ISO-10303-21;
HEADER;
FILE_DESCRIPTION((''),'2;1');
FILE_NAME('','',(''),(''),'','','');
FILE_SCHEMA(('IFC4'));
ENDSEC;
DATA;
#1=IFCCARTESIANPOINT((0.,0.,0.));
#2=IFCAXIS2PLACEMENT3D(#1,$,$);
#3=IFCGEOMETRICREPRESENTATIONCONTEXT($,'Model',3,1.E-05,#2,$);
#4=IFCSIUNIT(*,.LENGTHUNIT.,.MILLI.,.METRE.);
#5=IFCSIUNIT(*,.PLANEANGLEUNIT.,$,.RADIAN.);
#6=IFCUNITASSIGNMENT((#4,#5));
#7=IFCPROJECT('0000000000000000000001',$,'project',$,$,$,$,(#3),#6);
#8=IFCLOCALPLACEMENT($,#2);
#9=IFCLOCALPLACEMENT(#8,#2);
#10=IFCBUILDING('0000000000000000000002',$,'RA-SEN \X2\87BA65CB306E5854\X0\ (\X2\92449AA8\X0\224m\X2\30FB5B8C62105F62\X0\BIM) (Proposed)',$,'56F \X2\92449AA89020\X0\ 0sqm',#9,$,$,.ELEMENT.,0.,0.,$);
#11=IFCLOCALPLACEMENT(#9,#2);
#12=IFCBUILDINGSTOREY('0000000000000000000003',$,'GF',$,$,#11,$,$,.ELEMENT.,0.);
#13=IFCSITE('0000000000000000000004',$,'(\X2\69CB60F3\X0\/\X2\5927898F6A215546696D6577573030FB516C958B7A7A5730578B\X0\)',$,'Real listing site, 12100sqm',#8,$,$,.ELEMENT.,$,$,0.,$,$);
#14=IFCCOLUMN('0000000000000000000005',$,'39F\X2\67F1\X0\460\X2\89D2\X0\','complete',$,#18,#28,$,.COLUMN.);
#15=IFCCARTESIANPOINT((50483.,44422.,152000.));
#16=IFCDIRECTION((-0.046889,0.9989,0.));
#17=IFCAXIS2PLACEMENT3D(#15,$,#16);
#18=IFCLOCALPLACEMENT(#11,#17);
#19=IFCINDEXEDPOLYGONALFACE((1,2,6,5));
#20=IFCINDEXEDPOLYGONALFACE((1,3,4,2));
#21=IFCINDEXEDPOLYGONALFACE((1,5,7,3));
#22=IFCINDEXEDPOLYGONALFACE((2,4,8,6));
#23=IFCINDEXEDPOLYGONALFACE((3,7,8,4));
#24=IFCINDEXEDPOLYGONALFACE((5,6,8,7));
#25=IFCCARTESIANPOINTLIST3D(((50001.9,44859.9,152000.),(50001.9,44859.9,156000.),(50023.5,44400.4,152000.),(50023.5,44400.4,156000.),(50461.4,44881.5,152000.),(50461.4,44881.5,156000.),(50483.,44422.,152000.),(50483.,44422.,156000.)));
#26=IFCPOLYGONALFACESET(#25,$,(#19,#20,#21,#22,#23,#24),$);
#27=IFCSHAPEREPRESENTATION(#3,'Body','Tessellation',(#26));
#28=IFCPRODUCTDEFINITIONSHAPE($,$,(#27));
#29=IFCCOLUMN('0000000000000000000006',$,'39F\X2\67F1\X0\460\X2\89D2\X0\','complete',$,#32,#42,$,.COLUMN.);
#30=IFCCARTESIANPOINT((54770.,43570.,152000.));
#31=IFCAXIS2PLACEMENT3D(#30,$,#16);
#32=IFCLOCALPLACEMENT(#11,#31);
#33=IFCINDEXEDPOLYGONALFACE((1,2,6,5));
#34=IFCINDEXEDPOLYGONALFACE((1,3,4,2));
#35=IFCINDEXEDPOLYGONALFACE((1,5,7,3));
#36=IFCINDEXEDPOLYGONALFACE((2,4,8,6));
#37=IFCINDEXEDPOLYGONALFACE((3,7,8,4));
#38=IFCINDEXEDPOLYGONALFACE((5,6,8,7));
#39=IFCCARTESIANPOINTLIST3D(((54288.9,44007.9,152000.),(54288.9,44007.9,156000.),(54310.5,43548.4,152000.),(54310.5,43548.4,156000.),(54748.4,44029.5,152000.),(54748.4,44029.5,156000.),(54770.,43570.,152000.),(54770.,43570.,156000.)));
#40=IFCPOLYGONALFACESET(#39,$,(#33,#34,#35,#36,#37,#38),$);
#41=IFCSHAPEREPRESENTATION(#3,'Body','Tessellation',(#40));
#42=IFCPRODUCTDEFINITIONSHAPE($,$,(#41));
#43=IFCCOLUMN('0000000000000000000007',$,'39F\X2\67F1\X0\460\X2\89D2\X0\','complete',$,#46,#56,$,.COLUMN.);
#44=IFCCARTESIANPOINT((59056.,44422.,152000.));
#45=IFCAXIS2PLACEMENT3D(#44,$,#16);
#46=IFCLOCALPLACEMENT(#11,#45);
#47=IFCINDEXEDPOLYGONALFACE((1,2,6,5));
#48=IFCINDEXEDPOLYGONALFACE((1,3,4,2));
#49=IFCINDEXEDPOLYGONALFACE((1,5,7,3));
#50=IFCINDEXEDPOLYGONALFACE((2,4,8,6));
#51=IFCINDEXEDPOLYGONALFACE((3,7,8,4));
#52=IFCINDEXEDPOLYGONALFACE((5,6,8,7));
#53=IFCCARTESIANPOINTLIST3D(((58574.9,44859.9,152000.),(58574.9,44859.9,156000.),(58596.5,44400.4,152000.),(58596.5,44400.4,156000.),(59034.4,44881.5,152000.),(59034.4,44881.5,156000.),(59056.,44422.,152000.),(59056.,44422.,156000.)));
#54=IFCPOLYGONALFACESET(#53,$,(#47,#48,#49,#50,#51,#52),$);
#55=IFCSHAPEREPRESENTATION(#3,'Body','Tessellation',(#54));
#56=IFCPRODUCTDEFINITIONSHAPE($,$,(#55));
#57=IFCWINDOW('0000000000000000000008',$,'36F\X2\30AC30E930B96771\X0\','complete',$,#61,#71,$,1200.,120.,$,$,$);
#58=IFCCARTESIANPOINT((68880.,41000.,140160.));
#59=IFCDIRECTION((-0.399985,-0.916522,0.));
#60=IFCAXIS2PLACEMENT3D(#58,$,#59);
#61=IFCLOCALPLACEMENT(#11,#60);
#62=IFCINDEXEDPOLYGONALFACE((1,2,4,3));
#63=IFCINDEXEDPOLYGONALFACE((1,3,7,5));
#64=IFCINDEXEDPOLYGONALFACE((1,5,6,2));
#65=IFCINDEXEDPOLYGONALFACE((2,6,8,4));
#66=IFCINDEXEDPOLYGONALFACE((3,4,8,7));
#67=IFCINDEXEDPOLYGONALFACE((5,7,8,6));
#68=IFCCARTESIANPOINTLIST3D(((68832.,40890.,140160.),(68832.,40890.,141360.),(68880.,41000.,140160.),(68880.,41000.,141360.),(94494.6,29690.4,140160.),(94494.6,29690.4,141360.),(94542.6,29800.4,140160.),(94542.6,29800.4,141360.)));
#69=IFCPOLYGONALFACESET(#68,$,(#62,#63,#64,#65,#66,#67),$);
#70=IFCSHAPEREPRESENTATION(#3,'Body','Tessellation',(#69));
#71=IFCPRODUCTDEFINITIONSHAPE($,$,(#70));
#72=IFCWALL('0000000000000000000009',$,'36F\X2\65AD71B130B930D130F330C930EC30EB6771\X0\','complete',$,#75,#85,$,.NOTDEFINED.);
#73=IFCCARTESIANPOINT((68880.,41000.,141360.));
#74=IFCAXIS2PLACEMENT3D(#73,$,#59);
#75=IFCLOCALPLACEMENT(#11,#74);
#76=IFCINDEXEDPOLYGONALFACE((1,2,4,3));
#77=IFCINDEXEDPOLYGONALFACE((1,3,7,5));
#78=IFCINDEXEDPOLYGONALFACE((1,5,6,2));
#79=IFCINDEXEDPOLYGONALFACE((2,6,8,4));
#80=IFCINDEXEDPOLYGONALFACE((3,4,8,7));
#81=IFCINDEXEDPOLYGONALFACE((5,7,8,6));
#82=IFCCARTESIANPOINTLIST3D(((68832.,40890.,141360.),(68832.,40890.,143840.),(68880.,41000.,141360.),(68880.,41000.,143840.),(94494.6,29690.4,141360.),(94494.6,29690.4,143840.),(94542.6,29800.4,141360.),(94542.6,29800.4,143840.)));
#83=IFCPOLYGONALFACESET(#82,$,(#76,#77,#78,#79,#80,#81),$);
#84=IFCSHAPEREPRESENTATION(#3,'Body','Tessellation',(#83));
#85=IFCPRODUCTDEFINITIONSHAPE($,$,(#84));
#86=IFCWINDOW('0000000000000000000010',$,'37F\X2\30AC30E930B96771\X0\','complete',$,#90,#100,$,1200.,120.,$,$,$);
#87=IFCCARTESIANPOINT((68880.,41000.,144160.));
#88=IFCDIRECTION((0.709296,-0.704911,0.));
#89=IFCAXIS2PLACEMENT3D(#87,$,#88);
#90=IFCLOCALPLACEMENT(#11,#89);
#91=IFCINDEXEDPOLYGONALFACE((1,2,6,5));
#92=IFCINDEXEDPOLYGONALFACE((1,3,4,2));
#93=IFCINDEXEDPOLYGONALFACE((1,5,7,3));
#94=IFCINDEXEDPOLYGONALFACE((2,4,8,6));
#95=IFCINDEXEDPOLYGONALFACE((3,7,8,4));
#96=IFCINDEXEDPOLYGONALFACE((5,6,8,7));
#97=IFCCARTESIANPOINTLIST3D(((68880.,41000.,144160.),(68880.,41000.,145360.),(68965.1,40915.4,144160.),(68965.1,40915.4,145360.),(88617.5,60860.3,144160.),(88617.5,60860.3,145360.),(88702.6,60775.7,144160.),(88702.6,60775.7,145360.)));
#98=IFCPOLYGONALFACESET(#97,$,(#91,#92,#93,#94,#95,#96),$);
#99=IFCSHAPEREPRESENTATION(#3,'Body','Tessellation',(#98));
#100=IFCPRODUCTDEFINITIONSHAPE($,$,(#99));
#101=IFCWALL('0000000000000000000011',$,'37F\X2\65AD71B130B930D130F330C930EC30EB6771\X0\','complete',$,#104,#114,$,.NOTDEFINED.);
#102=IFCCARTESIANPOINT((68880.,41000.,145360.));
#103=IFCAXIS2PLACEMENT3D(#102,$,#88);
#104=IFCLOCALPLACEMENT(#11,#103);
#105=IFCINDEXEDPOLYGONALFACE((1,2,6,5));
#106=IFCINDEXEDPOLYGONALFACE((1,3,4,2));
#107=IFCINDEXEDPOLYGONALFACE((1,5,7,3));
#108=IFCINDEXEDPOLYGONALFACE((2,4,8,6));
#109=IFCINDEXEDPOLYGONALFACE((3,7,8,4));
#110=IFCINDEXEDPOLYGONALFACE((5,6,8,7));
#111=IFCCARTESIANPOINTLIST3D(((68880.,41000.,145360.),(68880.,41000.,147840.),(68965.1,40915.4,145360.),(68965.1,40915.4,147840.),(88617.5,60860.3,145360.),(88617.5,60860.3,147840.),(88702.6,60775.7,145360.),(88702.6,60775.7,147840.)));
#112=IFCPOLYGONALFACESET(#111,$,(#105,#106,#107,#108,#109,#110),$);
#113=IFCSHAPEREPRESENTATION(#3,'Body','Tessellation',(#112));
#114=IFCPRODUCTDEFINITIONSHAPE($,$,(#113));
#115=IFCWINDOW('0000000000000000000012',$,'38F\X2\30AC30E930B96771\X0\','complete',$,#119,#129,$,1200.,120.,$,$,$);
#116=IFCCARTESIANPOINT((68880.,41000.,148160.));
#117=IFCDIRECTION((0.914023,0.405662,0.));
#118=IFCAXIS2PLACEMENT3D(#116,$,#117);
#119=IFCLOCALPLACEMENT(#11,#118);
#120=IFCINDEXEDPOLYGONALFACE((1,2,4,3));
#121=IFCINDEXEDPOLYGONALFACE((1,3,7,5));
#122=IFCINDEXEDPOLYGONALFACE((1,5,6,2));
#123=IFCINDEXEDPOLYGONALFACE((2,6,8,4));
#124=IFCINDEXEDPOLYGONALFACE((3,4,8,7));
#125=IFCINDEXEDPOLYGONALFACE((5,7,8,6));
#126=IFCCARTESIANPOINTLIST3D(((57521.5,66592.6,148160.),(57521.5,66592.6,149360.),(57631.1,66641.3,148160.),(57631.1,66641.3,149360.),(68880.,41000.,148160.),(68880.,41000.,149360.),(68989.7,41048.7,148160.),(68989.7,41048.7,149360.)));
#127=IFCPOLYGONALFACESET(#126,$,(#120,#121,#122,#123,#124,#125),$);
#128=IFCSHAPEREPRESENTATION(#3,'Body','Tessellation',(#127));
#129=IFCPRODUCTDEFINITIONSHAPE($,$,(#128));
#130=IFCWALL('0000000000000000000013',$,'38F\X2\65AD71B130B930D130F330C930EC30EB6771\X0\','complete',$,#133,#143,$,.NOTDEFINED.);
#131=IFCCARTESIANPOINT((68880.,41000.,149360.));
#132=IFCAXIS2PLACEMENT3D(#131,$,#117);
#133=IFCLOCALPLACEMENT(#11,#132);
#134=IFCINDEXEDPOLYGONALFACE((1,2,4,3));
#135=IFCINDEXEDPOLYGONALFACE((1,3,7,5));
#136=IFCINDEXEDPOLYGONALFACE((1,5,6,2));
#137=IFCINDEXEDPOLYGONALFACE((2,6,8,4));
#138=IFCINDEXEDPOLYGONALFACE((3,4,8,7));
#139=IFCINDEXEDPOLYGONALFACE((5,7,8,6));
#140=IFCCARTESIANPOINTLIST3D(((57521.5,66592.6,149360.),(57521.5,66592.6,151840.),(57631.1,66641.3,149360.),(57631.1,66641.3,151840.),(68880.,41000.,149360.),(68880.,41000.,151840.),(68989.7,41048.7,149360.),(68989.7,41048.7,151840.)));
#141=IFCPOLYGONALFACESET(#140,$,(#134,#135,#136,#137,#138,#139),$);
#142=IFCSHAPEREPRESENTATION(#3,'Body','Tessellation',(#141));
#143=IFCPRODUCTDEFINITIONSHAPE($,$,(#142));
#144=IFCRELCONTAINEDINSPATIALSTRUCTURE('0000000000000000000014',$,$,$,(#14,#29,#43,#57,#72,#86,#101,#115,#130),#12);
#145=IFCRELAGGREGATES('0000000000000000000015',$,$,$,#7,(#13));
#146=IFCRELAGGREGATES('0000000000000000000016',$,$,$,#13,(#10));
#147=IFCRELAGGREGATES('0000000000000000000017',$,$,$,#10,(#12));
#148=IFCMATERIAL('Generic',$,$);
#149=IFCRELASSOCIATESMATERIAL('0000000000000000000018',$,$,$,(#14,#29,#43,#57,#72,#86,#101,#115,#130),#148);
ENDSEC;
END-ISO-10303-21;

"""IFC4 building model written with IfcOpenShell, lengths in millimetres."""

from ifc_helpers import new_model, si_unit, frame, frame_2d, origin, place, context, project, spatial, rectangle, extrude, material, element, save


model = new_model("IFC4")

# Units and contexts
model_context = context("Model", 3, precision=1e-05, world=origin())
ifc_project = project(units=[si_unit("LENGTHUNIT", "METRE", prefix="MILLI"), si_unit("PLANEANGLEUNIT", "RADIAN")], contexts=[model_context])

# Site, building, storey
site_placement = place(None, origin())
site = spatial("IfcSite", under=ifc_project, at=site_placement, Name="(構想/大規模商業敷地・公開空地型)", ObjectType="Real listing site, 12100sqm", CompositionType="ELEMENT", RefElevation=0.0)
building_placement = place(site_placement, origin())
building = spatial("IfcBuilding", under=site, at=building_placement, Name="RA-SEN 螺旋の塔 (鉄骨224m・完成形BIM) (Proposed)", ObjectType="56F 鉄骨造 0sqm", CompositionType="ELEMENT", ElevationOfRefHeight=0.0, ElevationOfTerrain=0.0)
storey_placement = place(building_placement, origin())
storey = spatial("IfcBuildingStorey", under=building, at=storey_placement, Name="GF", CompositionType="ELEMENT", Elevation=0.0)

# Columns
ifc_material = material(Name="Generic")
column_1_placement = place(storey_placement, frame((50483.0, 44422.0, 152000.0), x_axis=(-0.046889, 0.9989, 0.0)))
element("IfcColumn", 1, at=column_1_placement, inside=storey, material=ifc_material, Name="39F柱460角", Description="complete", PredefinedType="COLUMN", context=model_context, shape_type="SweptSolid", body=[
    extrude(rectangle(XDim=460.0, YDim=460.0, at=frame_2d((230.0, 230.0))), frame((50483.0, 44422.0, 152000.0), x_axis=(-0.046889, 0.9989, 0.0)), (0.0, 0.0, 1.0), 4000.0),
])
column_2_placement = place(storey_placement, frame((54770.0, 43570.0, 152000.0), x_axis=(-0.046889, 0.9989, 0.0)))
element("IfcColumn", 2, at=column_2_placement, inside=storey, material=ifc_material, Name="39F柱460角", Description="complete", PredefinedType="COLUMN", context=model_context, shape_type="SweptSolid", body=[
    extrude(rectangle(XDim=460.0, YDim=460.0, at=frame_2d((230.0, 230.0))), frame((54770.0, 43570.0, 152000.0), x_axis=(-0.046889, 0.9989, 0.0)), (0.0, 0.0, 1.0), 4000.0),
])
column_3_placement = place(storey_placement, frame((59056.0, 44422.0, 152000.0), x_axis=(-0.046889, 0.9989, 0.0)))
element("IfcColumn", 3, at=column_3_placement, inside=storey, material=ifc_material, Name="39F柱460角", Description="complete", PredefinedType="COLUMN", context=model_context, shape_type="SweptSolid", body=[
    extrude(rectangle(XDim=460.0, YDim=460.0, at=frame_2d((230.0, 230.0))), frame((59056.0, 44422.0, 152000.0), x_axis=(-0.046889, 0.9989, 0.0)), (0.0, 0.0, 1.0), 4000.0),
])

# Window
window_1_placement = place(storey_placement, frame((68880.0, 41000.0, 140160.0), x_axis=(-0.399985, -0.916522, 0.0)))
element("IfcWindow", 4, at=window_1_placement, inside=storey, material=ifc_material, Name="36Fガラス東", Description="complete", OverallHeight=1200.0, OverallWidth=120.0, context=model_context, shape_type="SweptSolid", body=[
    extrude(rectangle(XDim=120.0, YDim=28000.0, at=frame_2d((60.0, 14000.0))), frame((68880.0, 41000.0, 140160.0), x_axis=(-0.399985, -0.916522, 0.0)), (0.0, 0.0, 1.0), 1200.0),
])

# Wall
wall_1_placement = place(storey_placement, frame((68880.0, 41000.0, 141360.0), x_axis=(-0.399985, -0.916522, 0.0)))
element("IfcWall", 5, at=wall_1_placement, inside=storey, material=ifc_material, Name="36F断熱スパンドレル東", Description="complete", PredefinedType="NOTDEFINED", context=model_context, shape_type="SweptSolid", body=[
    extrude(rectangle(XDim=120.0, YDim=28000.0, at=frame_2d((60.0, 14000.0))), frame((68880.0, 41000.0, 141360.0), x_axis=(-0.399985, -0.916522, 0.0)), (0.0, 0.0, 1.0), 2480.0),
])

# Window
window_2_placement = place(storey_placement, frame((68880.0, 41000.0, 144160.0), x_axis=(0.709296, -0.704911, 0.0)))
element("IfcWindow", 6, at=window_2_placement, inside=storey, material=ifc_material, Name="37Fガラス東", Description="complete", OverallHeight=1200.0, OverallWidth=120.0, context=model_context, shape_type="SweptSolid", body=[
    extrude(rectangle(XDim=120.0, YDim=28000.0, at=frame_2d((60.0, 14000.0))), frame((68880.0, 41000.0, 144160.0), x_axis=(0.709296, -0.704911, 0.0)), (0.0, 0.0, 1.0), 1200.0),
])

# Wall
wall_2_placement = place(storey_placement, frame((68880.0, 41000.0, 145360.0), x_axis=(0.709296, -0.704911, 0.0)))
element("IfcWall", 7, at=wall_2_placement, inside=storey, material=ifc_material, Name="37F断熱スパンドレル東", Description="complete", PredefinedType="NOTDEFINED", context=model_context, shape_type="SweptSolid", body=[
    extrude(rectangle(XDim=120.0, YDim=28000.0, at=frame_2d((60.0, 14000.0))), frame((68880.0, 41000.0, 145360.0), x_axis=(0.709296, -0.704911, 0.0)), (0.0, 0.0, 1.0), 2480.0),
])

# Window
window_3_placement = place(storey_placement, frame((68880.0, 41000.0, 148160.0), x_axis=(0.914023, 0.405662, 0.0)))
element("IfcWindow", 8, at=window_3_placement, inside=storey, material=ifc_material, Name="38Fガラス東", Description="complete", OverallHeight=1200.0, OverallWidth=120.0, context=model_context, shape_type="SweptSolid", body=[
    extrude(rectangle(XDim=120.0, YDim=28000.0, at=frame_2d((60.0, 14000.0))), frame((68880.0, 41000.0, 148160.0), x_axis=(0.914023, 0.405662, 0.0)), (0.0, 0.0, 1.0), 1200.0),
])

# Wall
wall_3_placement = place(storey_placement, frame((68880.0, 41000.0, 149360.0), x_axis=(0.914023, 0.405662, 0.0)))
element("IfcWall", 9, at=wall_3_placement, inside=storey, material=ifc_material, Name="38F断熱スパンドレル東", Description="complete", PredefinedType="NOTDEFINED", context=model_context, shape_type="SweptSolid", body=[
    extrude(rectangle(XDim=120.0, YDim=28000.0, at=frame_2d((60.0, 14000.0))), frame((68880.0, 41000.0, 149360.0), x_axis=(0.914023, 0.405662, 0.0)), (0.0, 0.0, 1.0), 2480.0),
])

save(model, "model.ifc")
